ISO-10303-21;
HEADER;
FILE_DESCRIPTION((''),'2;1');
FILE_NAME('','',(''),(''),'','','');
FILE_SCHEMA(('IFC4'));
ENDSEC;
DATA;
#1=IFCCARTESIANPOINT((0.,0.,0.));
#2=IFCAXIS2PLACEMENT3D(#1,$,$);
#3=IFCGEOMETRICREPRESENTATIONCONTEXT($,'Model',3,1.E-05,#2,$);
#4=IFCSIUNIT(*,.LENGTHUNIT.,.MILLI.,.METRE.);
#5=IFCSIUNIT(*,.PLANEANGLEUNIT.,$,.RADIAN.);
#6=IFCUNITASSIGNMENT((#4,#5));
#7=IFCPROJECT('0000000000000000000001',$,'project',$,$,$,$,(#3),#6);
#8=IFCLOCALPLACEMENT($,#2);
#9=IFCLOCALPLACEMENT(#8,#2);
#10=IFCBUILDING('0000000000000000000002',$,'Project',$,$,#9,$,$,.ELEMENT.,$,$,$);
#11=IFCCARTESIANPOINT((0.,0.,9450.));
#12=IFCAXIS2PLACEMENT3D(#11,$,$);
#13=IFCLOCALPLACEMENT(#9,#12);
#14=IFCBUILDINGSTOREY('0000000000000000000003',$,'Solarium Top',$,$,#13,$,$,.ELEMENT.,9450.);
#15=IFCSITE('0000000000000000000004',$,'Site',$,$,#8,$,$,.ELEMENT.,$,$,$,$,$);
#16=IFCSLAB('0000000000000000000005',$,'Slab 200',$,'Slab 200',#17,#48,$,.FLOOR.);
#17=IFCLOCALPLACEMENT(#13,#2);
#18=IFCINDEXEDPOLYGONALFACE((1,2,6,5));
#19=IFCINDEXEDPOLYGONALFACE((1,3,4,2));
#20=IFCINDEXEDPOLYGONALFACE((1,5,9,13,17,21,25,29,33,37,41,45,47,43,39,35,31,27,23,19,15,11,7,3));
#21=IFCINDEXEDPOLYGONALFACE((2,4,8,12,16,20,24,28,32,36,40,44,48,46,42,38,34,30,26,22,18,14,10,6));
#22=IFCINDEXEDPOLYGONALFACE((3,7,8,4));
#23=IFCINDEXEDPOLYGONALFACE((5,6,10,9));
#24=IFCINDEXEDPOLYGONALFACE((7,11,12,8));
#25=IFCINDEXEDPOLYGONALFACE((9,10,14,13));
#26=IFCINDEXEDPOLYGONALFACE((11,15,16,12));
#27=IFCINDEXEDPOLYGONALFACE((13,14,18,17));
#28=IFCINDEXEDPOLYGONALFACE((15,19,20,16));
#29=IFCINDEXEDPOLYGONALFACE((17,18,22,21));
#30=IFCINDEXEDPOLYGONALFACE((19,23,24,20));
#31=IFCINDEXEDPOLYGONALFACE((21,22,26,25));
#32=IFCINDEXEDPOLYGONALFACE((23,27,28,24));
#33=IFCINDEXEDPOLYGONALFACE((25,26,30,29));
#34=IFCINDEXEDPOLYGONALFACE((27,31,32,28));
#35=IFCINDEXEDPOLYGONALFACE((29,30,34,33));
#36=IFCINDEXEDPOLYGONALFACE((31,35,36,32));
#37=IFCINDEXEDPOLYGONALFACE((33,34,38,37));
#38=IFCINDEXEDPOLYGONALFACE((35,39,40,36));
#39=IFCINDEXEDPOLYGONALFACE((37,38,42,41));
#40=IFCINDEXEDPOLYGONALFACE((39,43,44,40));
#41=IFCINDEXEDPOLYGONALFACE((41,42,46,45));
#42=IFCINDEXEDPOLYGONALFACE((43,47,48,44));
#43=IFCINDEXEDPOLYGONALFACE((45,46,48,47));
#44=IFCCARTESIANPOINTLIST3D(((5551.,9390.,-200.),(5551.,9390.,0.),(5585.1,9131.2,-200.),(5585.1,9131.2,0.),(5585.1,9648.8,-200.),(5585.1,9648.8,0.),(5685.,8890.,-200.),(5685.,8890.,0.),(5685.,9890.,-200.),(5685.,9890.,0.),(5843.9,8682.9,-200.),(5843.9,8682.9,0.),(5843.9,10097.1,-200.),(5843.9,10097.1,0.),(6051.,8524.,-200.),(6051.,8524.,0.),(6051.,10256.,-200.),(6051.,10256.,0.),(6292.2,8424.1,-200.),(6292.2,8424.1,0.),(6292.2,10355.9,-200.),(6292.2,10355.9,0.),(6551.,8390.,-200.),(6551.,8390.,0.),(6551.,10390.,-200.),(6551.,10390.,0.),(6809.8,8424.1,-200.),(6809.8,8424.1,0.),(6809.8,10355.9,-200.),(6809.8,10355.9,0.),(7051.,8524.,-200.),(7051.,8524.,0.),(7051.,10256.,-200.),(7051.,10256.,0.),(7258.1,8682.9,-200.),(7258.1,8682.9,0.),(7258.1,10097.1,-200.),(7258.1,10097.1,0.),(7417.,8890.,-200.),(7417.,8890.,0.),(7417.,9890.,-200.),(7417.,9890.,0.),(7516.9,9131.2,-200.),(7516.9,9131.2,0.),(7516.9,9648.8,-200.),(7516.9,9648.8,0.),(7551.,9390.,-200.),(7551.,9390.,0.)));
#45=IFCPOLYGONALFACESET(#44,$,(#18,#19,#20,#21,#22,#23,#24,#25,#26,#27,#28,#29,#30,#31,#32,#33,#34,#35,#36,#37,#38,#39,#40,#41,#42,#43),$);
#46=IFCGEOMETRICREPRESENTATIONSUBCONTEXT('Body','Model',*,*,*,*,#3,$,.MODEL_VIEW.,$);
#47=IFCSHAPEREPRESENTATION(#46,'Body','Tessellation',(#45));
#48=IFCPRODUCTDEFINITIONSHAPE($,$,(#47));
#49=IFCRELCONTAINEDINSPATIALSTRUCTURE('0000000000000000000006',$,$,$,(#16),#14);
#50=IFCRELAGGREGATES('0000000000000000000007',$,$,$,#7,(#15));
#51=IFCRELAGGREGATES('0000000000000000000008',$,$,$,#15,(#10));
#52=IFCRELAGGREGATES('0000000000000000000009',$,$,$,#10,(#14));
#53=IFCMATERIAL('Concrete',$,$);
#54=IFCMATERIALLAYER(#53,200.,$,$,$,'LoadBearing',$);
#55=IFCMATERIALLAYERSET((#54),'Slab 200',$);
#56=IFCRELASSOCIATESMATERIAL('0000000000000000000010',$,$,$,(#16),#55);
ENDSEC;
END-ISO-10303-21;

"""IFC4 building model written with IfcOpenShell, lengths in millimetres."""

from ifc_helpers import new_model, si_unit, frame, origin, place, context, subcontext, project, spatial, polyline, outline, extrude, material, layer, layer_set, layer_usage, element, save


model = new_model("IFC4")

# Units and contexts
model_context = context("Model", 3, precision=1e-05, world=origin())
body_context = subcontext(model_context, "Body", "Model", "MODEL_VIEW")
ifc_project = project(units=[si_unit("LENGTHUNIT", "METRE", prefix="MILLI"), si_unit("PLANEANGLEUNIT", "RADIAN")], contexts=[model_context])

# Site, building, storey
site_placement = place(None, origin())
site = spatial("IfcSite", under=ifc_project, at=site_placement, Name="Site", CompositionType="ELEMENT")
building_placement = place(site_placement, origin())
building = spatial("IfcBuilding", under=site, at=building_placement, Name="Project", CompositionType="ELEMENT")
storey_placement = place(building_placement, frame((0.0, 0.0, 9450.0)))
storey = spatial("IfcBuildingStorey", under=building, at=storey_placement, Name="Solarium Top", CompositionType="ELEMENT", Elevation=9450.0)

# Slab
ifc_material = material(Name="Concrete")
ifc_layer = layer(ifc_material, 200.0, Category="LoadBearing")
ifc_layer_set = layer_set([ifc_layer], Name="Slab 200")
ifc_layer_usage = layer_usage(ifc_layer_set, "AXIS3", "NEGATIVE", 0.0)
slab_placement = place(storey_placement, origin())
element("IfcSlab", 1, at=slab_placement, inside=storey, material=ifc_layer_usage, Name="Slab 200", ObjectType="Slab 200", PredefinedType="FLOOR", context=body_context, shape_type="SweptSolid", body=[
    extrude(outline(polyline([(7551.0, 9390.0), (7516.9, 9648.8), (7417.0, 9890.0), (7258.1, 10097.1), (7051.0, 10256.0), (6809.8, 10355.9), (6551.0, 10390.0), (6292.2, 10355.9), (6051.0, 10256.0), (5843.9, 10097.1), (5685.0, 9890.0), (5585.1, 9648.8), (5551.0, 9390.0), (5585.1, 9131.2), (5685.0, 8890.0), (5843.9, 8682.9), (6051.0, 8524.0), (6292.2, 8424.1), (6551.0, 8390.0), (6809.8, 8424.1), (7051.0, 8524.0), (7258.1, 8682.9), (7417.0, 8890.0), (7516.9, 9131.2), (7551.0, 9390.0)])), frame((0.0, 0.0, -200.0)), (0.0, 0.0, 1.0), 200.0),
])

save(model, "model.ifc")
